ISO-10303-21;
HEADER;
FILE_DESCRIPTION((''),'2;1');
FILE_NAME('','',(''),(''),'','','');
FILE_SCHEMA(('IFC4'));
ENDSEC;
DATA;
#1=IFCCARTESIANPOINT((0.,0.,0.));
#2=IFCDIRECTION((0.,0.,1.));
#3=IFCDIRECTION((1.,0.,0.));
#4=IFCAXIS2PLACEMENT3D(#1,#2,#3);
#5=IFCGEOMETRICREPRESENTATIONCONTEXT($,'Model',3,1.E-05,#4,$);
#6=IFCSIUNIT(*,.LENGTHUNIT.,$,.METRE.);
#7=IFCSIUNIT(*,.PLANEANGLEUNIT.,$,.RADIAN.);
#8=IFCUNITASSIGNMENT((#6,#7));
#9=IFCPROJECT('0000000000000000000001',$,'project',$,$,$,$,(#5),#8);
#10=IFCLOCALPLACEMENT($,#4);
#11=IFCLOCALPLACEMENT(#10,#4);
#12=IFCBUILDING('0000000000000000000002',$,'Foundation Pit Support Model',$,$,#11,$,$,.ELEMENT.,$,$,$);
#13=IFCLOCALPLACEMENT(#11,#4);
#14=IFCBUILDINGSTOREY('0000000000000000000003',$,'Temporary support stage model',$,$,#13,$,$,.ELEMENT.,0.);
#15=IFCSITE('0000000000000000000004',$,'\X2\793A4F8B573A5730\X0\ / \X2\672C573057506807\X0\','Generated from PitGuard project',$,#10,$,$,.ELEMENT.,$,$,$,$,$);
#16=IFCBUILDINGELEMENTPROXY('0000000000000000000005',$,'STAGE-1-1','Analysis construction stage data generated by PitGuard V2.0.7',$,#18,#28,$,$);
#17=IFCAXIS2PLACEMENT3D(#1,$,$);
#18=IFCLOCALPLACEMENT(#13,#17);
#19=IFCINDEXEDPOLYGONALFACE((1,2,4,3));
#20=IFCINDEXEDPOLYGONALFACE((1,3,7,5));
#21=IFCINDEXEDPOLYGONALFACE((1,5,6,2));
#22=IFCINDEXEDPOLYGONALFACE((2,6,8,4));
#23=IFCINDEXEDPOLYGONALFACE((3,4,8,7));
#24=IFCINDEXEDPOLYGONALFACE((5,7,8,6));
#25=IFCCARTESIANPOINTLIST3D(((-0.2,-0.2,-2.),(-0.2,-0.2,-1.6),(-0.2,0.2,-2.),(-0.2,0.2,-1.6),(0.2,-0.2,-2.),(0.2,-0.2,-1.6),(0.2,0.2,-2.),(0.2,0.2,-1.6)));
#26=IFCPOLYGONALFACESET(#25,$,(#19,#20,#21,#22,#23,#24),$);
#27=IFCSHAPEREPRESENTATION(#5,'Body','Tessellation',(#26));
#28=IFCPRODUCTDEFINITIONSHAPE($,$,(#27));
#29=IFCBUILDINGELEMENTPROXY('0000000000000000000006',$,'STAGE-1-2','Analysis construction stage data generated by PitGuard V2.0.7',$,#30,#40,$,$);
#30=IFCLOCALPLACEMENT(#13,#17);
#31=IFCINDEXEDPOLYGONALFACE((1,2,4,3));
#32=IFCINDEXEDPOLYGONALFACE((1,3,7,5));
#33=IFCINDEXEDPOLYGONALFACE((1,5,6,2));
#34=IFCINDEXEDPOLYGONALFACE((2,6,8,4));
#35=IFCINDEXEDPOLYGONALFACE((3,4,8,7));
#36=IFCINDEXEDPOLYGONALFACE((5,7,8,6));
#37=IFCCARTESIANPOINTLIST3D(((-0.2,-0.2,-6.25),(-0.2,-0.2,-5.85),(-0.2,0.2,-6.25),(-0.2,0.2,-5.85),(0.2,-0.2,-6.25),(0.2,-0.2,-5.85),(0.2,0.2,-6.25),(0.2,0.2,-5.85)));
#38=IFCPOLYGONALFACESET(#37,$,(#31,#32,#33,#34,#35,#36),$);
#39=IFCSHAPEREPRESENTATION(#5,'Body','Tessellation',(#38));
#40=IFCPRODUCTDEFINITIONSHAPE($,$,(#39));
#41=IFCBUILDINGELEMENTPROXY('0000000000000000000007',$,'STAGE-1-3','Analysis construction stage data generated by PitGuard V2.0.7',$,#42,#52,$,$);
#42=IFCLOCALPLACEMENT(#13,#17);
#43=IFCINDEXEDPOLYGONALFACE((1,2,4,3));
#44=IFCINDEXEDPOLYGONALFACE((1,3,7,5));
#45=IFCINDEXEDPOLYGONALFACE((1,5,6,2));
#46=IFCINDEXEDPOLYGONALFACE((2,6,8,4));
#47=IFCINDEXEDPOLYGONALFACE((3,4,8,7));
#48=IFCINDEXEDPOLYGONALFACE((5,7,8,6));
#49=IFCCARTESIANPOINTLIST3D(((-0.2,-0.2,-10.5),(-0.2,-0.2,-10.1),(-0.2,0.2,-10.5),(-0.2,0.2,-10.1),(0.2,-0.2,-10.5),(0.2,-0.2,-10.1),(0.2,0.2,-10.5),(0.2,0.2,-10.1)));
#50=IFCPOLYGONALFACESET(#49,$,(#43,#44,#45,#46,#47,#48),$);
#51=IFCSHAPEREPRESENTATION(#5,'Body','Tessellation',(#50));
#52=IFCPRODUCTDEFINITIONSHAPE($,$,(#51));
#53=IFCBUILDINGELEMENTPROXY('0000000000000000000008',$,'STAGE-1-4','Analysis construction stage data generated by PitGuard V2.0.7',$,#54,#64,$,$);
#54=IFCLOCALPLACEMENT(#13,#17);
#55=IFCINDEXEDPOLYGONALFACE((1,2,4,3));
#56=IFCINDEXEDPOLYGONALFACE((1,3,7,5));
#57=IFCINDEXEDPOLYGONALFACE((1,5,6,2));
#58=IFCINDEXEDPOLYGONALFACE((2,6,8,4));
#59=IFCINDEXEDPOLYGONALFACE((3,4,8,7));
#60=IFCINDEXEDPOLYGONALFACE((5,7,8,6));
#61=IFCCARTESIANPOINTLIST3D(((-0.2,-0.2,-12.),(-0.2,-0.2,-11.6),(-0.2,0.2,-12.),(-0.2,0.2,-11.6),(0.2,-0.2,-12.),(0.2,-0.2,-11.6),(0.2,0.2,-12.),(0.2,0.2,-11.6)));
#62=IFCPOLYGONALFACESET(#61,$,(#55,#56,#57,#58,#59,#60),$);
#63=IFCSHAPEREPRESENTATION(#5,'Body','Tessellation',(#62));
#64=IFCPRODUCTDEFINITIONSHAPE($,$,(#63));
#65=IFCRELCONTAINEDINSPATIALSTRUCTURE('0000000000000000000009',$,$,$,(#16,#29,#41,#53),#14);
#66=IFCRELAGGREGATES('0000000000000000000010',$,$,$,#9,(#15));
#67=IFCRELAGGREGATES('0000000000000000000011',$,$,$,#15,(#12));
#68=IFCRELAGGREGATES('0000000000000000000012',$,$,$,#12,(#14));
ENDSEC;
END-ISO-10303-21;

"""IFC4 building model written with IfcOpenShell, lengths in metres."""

from ifc_helpers import new_model, si_unit, frame, origin_with_axes, origin_2d, place, context, project, spatial, rectangle, extrude, element, save


model = new_model("IFC4")

# Units and contexts
model_context = context("Model", 3, precision=1e-05, world=origin_with_axes())
ifc_project = project(units=[si_unit("LENGTHUNIT", "METRE"), si_unit("PLANEANGLEUNIT", "RADIAN")], contexts=[model_context])

# Site, building, storey
site_placement = place(None, origin_with_axes())
site = spatial("IfcSite", under=ifc_project, at=site_placement, Name="示例场地 / 本地坐标", Description="Generated from PitGuard project", CompositionType="ELEMENT")
building_placement = place(site_placement, origin_with_axes())
building = spatial("IfcBuilding", under=site, at=building_placement, Name="Foundation Pit Support Model", CompositionType="ELEMENT")
storey_placement = place(building_placement, origin_with_axes())
storey = spatial("IfcBuildingStorey", under=building, at=storey_placement, Name="Temporary support stage model", CompositionType="ELEMENT", Elevation=0.0)

# Building element proxies
for number, where, z_axis, x_axis, name in (
    (1, (0.0, 0.0, -2.0), (0.0, 0.0, 1.0), (1.0, 0.0, 0.0), "STAGE-1-1"),
    (2, (0.0, 0.0, -6.25), (0.0, 0.0, 1.0), (1.0, 0.0, 0.0), "STAGE-1-2"),
    (3, (0.0, 0.0, -10.5), (0.0, 0.0, 1.0), (1.0, 0.0, 0.0), "STAGE-1-3"),
    (4, (0.0, 0.0, -12.0), (0.0, 0.0, 1.0), (1.0, 0.0, 0.0), "STAGE-1-4"),
):
    element("IfcBuildingElementProxy", number, at=place(storey_placement, frame(where, z_axis=z_axis, x_axis=x_axis)), inside=storey, Name=name, Description="Analysis construction stage data generated by PitGuard V2.0.7", context=model_context, shape_type="SweptSolid", body=[
        extrude(rectangle(XDim=0.4, YDim=0.4, at=origin_2d()), origin_with_axes(), (0.0, 0.0, 1.0), 0.4),
    ])

save(model, "model.ifc")
